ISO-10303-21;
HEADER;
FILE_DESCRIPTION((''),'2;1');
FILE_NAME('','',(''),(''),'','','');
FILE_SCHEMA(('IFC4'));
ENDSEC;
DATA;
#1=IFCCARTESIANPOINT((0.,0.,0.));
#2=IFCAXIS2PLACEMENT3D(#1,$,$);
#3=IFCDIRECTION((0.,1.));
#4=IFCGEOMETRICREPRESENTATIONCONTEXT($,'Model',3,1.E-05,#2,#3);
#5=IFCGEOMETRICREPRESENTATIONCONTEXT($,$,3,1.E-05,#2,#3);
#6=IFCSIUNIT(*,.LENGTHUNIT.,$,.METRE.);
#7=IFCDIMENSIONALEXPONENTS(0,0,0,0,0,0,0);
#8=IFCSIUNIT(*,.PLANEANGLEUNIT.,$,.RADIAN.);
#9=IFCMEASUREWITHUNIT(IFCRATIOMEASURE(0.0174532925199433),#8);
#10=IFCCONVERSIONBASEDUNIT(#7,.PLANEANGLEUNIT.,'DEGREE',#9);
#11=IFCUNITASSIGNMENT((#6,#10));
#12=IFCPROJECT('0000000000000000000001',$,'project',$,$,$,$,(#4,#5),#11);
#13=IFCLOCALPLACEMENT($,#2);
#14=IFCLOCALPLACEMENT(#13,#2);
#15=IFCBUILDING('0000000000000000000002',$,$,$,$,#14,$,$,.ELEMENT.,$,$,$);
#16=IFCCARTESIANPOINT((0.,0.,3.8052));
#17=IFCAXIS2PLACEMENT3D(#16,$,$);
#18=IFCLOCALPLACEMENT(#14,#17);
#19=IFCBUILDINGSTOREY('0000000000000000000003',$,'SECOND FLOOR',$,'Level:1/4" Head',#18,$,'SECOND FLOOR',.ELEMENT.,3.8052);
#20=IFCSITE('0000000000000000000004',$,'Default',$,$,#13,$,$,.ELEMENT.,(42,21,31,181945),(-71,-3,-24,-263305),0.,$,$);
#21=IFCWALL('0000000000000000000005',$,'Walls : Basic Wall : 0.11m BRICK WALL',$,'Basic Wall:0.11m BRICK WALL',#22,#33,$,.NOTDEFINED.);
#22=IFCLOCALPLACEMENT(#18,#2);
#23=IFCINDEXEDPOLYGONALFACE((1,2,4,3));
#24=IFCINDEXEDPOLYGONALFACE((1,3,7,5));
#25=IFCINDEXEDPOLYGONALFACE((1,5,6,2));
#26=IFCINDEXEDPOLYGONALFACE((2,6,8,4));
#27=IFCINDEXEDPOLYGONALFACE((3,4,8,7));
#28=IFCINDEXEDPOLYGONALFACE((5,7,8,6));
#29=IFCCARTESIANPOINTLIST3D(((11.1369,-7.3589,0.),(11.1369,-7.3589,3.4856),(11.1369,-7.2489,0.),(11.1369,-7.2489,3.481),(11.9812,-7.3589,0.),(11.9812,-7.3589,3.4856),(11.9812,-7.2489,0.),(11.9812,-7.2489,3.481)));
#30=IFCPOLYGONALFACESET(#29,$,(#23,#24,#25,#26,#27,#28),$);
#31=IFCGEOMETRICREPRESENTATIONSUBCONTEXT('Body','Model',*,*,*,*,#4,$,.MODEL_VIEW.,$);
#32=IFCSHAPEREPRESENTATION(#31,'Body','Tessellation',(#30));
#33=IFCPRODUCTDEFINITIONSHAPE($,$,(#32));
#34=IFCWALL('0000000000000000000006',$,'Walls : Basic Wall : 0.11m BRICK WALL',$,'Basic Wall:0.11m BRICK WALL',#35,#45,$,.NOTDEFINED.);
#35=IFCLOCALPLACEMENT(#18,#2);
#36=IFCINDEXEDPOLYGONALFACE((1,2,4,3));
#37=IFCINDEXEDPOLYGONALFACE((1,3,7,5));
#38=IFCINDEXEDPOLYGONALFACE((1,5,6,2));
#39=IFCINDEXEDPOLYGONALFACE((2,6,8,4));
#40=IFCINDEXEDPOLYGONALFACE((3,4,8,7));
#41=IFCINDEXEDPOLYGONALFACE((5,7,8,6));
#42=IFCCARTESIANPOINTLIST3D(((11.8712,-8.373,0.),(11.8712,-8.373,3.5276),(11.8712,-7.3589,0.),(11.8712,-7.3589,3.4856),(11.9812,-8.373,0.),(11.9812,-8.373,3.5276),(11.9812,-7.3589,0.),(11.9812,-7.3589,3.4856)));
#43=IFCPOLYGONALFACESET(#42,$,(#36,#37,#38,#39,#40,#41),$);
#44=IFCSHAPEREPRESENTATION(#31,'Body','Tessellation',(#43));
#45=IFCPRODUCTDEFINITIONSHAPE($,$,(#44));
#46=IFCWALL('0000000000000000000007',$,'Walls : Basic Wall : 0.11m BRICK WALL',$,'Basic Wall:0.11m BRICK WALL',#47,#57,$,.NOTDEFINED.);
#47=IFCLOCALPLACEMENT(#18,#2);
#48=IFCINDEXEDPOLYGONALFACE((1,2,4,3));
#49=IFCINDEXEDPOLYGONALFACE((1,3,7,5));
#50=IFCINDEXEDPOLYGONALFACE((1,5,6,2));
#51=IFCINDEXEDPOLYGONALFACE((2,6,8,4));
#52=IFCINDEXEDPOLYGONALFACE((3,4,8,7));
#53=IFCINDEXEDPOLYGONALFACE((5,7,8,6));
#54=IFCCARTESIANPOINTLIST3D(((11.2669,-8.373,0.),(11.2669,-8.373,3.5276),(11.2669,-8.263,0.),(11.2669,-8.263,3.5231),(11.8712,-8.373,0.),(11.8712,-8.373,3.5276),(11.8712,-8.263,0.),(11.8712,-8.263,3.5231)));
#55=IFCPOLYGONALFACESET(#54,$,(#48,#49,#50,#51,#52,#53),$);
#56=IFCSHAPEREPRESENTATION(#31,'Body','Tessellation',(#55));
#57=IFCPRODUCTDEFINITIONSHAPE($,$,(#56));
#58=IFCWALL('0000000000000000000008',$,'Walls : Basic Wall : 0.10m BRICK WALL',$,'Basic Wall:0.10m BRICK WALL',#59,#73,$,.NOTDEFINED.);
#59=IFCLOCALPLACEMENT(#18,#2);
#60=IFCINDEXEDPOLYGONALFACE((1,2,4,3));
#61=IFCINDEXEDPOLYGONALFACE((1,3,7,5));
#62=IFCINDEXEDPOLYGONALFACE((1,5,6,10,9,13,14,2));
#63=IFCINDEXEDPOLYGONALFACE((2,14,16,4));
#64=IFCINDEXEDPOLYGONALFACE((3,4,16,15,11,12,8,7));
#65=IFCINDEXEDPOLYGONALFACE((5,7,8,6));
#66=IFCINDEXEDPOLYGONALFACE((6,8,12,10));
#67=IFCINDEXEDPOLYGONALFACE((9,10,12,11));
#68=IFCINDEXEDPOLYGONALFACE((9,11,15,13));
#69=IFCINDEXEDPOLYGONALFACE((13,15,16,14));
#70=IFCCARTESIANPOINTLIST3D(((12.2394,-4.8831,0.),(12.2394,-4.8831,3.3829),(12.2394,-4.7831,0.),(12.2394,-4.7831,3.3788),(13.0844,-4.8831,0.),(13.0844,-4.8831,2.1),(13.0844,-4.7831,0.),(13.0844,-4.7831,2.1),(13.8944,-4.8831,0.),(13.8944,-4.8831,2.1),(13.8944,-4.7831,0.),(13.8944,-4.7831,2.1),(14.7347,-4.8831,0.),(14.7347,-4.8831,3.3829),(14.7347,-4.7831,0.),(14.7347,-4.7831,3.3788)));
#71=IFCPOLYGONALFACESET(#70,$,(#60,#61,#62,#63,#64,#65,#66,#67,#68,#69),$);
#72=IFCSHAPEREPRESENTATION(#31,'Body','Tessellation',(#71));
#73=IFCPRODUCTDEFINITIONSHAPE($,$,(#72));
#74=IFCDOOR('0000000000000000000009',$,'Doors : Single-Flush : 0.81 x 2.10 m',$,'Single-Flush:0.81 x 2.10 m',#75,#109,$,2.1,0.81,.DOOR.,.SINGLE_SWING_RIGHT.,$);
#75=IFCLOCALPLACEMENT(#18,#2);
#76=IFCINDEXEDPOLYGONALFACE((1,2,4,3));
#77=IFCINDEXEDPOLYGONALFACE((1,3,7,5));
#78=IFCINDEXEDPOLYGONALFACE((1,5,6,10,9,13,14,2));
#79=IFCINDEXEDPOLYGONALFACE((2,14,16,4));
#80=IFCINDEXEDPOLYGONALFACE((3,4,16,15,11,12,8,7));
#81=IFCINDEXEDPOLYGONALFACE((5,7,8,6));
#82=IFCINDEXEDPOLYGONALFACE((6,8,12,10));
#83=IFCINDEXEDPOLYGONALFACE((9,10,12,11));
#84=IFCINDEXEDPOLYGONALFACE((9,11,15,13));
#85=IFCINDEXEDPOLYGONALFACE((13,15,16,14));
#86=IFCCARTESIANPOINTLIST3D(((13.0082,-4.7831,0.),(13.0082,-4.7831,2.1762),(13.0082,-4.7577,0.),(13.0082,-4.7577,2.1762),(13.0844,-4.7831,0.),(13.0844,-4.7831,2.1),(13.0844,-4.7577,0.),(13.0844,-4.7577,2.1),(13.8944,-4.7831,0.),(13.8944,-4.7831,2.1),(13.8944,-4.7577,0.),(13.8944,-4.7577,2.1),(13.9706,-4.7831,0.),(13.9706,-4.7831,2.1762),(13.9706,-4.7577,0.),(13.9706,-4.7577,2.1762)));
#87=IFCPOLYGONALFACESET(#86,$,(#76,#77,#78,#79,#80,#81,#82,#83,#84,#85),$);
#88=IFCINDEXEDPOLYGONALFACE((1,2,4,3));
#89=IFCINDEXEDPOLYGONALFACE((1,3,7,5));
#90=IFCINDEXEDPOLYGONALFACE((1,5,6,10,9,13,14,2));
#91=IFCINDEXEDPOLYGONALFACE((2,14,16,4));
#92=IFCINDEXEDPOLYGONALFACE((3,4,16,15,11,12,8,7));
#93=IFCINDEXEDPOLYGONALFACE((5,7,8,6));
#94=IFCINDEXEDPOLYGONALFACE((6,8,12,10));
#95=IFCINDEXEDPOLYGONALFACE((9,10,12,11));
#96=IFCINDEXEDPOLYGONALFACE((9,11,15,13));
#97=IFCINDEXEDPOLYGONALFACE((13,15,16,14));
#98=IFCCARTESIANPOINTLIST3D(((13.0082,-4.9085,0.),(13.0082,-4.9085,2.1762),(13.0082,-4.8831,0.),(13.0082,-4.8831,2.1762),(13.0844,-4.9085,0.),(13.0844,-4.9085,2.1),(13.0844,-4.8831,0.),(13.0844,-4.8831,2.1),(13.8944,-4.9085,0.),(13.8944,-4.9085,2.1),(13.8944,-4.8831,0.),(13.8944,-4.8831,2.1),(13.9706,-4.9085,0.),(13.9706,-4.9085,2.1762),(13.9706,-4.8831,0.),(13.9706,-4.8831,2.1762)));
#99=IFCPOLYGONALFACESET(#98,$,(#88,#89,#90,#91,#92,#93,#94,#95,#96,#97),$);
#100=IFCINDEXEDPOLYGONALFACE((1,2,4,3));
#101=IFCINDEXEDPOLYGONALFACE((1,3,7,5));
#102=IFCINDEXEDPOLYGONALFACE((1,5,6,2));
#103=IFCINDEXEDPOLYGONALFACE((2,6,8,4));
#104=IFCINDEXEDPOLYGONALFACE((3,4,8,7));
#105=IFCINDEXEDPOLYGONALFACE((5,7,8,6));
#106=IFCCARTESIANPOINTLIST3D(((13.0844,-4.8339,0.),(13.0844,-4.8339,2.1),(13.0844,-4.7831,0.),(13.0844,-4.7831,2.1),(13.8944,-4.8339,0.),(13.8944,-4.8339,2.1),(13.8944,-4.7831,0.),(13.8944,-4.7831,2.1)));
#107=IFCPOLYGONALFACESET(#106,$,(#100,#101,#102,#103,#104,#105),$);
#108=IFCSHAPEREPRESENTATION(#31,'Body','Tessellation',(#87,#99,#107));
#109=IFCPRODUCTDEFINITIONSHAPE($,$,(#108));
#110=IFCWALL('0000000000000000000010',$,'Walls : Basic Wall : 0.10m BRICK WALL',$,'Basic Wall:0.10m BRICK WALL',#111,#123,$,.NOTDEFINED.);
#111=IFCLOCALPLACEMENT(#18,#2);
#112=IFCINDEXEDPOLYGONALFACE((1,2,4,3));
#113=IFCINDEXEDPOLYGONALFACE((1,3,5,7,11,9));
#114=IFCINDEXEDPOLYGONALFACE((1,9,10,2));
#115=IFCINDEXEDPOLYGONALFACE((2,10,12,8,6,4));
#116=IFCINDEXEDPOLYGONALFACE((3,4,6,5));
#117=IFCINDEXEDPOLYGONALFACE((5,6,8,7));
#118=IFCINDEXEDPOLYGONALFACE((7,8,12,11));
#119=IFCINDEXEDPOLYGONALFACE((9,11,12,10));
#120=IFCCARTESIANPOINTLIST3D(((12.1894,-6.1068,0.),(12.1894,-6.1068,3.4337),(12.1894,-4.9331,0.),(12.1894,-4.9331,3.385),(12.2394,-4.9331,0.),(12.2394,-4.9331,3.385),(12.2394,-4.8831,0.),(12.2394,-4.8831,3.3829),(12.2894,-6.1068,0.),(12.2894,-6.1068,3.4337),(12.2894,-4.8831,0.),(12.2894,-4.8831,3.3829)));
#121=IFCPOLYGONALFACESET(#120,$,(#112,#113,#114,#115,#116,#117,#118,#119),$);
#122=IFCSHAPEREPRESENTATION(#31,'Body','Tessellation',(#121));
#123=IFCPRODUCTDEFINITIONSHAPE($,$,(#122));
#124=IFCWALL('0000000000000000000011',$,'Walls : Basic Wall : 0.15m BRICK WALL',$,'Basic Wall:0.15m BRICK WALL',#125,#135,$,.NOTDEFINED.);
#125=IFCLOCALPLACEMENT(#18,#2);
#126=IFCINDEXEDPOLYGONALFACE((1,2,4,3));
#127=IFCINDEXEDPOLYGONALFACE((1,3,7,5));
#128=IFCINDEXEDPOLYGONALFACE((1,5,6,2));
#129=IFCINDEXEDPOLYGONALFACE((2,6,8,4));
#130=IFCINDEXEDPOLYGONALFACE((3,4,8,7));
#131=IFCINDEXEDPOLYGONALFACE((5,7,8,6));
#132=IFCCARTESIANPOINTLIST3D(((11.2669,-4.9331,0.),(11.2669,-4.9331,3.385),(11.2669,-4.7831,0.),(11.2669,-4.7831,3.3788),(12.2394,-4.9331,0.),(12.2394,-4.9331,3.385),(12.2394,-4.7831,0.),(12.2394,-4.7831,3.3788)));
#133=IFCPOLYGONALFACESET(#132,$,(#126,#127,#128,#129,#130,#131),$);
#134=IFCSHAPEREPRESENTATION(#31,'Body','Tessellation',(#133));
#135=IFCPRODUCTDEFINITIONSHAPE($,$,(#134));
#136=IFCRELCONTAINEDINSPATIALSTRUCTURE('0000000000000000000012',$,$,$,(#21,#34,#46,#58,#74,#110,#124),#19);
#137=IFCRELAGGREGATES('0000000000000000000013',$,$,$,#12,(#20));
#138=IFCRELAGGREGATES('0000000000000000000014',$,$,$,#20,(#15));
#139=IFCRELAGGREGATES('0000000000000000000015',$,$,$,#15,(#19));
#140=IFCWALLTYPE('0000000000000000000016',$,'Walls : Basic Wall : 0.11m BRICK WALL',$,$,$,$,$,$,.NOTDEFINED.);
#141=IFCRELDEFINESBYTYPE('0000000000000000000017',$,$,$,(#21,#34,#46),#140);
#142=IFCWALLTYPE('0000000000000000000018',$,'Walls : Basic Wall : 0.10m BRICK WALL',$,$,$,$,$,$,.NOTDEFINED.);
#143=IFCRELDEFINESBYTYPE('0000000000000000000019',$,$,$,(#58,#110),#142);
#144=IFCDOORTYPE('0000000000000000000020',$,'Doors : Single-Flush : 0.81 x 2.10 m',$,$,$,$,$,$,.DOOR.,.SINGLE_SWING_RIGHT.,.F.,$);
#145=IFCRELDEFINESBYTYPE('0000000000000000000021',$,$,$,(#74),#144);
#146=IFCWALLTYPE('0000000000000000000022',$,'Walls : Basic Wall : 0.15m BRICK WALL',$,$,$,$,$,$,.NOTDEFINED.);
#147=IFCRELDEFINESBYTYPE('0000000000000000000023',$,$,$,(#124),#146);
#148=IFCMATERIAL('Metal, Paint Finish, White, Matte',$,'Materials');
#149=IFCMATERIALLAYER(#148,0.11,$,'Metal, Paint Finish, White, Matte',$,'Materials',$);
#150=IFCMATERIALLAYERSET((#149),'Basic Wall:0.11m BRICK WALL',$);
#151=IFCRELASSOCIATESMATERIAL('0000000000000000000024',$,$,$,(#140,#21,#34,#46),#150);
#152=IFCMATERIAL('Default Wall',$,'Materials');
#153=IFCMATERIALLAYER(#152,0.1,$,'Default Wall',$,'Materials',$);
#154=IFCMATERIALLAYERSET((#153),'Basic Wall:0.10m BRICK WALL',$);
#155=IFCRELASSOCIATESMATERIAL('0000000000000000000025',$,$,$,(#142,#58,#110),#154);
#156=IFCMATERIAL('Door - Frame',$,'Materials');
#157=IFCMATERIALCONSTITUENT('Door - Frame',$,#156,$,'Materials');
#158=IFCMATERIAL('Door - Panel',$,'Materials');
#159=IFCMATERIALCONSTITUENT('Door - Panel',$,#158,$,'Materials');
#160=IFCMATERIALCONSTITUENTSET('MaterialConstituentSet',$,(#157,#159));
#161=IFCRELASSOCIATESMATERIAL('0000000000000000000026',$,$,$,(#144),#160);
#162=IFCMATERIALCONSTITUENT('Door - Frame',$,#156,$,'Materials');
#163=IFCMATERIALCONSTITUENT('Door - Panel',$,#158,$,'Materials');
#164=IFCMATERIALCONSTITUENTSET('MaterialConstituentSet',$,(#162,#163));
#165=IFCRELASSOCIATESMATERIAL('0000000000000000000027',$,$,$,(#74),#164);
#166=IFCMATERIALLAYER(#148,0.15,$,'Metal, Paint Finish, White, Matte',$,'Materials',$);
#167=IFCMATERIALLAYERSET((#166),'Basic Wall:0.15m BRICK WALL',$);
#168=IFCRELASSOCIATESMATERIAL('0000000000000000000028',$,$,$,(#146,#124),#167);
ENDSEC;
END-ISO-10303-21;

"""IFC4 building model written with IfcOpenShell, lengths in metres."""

from ifc_helpers import new_model, entity, si_unit, converted_unit, direction, frame, frame_2d, origin, origin_2d_with_axis, place, context, subcontext, project, spatial, polyline, rectangle, outline, extrude, clip, bounded_halfspace, source, transform, mapped, material, layer, layer_set, layer_usage, constituent, constituent_set, type_object, type_shapes, element, fill, save


model = new_model("IFC4")

# Units and contexts
model_context = context("Model", 3, precision=1e-05, world=origin(), true_north=direction((0.0, 1.0)))
context_of_model = context(None, 3, precision=1e-05, world=origin(), true_north=direction((0.0, 1.0)))
body_context = subcontext(model_context, "Body", "Model", "MODEL_VIEW")
ifc_project = project(units=[si_unit("LENGTHUNIT", "METRE"), converted_unit("PLANEANGLEUNIT", "DEGREE", entity("IfcRatioMeasure", 0.0174532925199433), si_unit("PLANEANGLEUNIT", "RADIAN"), dimensions=[0, 0, 0, 0, 0, 0, 0])], contexts=[model_context, context_of_model])

# Site, building, storey
site_placement = place(None, origin())
site = spatial("IfcSite", under=ifc_project, at=site_placement, Name="Default", CompositionType="ELEMENT", RefLatitude=(42, 21, 31, 181945), RefLongitude=(-71, -3, -24, -263305), RefElevation=0.0)
building_placement = place(site_placement, origin())
building = spatial("IfcBuilding", under=site, at=building_placement, CompositionType="ELEMENT")
storey_placement = place(building_placement, frame((0.0, 0.0, 3.8052)))
storey = spatial("IfcBuildingStorey", under=building, at=storey_placement, Name="SECOND FLOOR", ObjectType="Level:1/4\" Head", LongName="SECOND FLOOR", CompositionType="ELEMENT", Elevation=3.8052)

# Shared definitions
ifc_material_1 = material(Name="Metal, Paint Finish, White, Matte", Category="Materials")

# Shared definitions
ifc_material_2 = material(Name="Door - Frame", Category="Materials")
ifc_material_3 = material(Name="Door - Panel", Category="Materials")

# Walls
ifc_layer_1 = layer(ifc_material_1, 0.11, Name="Metal, Paint Finish, White, Matte", Category="Materials")
ifc_layer_set_1 = layer_set([ifc_layer_1], Name="Basic Wall:0.11m BRICK WALL")
ifc_layer_usage_1 = layer_usage(ifc_layer_set_1, "AXIS2", "NEGATIVE", 0.055)
wall_type_1 = type_object("IfcWallType", Name="Walls : Basic Wall : 0.11m BRICK WALL", PredefinedType="NOTDEFINED", material=ifc_layer_set_1)
wall_1_placement = place(storey_placement, frame((11.9812, -7.3039, 0.0), z_axis=(0.0, 0.0, 1.0), x_axis=(-1.0, 0.0, 0.0)))
element("IfcWall", 1, at=wall_1_placement, inside=storey, type_object=wall_type_1, material=ifc_layer_usage_1, Name="Walls : Basic Wall : 0.11m BRICK WALL", ObjectType="Basic Wall:0.11m BRICK WALL", PredefinedType="NOTDEFINED", context=body_context, shape_type="Clipping", body=[
    clip(extrude(rectangle(XDim=0.8442, YDim=0.11, at=frame_2d((0.4221, 0.0), x_axis=(-1.0, 0.0))), origin(), (0.0, 0.0, 1.0), 3.4856), bounded_halfspace(frame((0.0, -0.055, 3.481), z_axis=(0.0, 0.041435, -0.999141), x_axis=(1.0, 0.0, 0.0)), True, frame((0.0, -0.055, 3.481)), polyline([(0.0, 0.0), (0.8442, 0.0), (0.8442, 0.11), (0.11, 0.11), (0.0, 0.11), (0.0, 0.0)]))),
])
ifc_layer_usage_2 = layer_usage(ifc_layer_set_1, "AXIS2", "NEGATIVE", 0.055)
wall_2_placement = place(storey_placement, frame((11.9262, -8.373, 0.0), z_axis=(0.0, 0.0, 1.0), x_axis=(0.0, 1.0, 0.0)))
element("IfcWall", 2, at=wall_2_placement, inside=storey, type_object=wall_type_1, material=ifc_layer_usage_2, Name="Walls : Basic Wall : 0.11m BRICK WALL", ObjectType="Basic Wall:0.11m BRICK WALL", PredefinedType="NOTDEFINED", context=body_context, shape_type="Clipping", body=[
    clip(extrude(rectangle(XDim=1.0141, YDim=0.11, at=frame_2d((0.5071, 0.0), x_axis=(-1.0, 0.0))), origin(), (0.0, 0.0, 1.0), 3.5276), bounded_halfspace(frame((0.0, -0.055, 3.5276), z_axis=(-0.041435, 0.0, -0.999141), x_axis=(0.0, 1.0, 0.0)), True, frame((0.0, -0.055, 3.5276)), polyline([(0.0, 0.0), (1.0141, 0.0), (1.0141, 0.11), (0.11, 0.11), (0.0, 0.11), (0.0, 0.0)]))),
])
ifc_layer_usage_3 = layer_usage(ifc_layer_set_1, "AXIS2", "NEGATIVE", 0.055)
wall_3_placement = place(storey_placement, frame((11.2669, -8.318, 0.0)))
element("IfcWall", 3, at=wall_3_placement, inside=storey, type_object=wall_type_1, material=ifc_layer_usage_3, Name="Walls : Basic Wall : 0.11m BRICK WALL", ObjectType="Basic Wall:0.11m BRICK WALL", PredefinedType="NOTDEFINED", context=body_context, shape_type="Clipping", body=[
    clip(extrude(rectangle(XDim=0.6042, YDim=0.11, at=frame_2d((0.3021, 0.0), x_axis=(-1.0, 0.0))), origin(), (0.0, 0.0, 1.0), 3.5276), bounded_halfspace(frame((0.0, -0.055, 3.5276), z_axis=(0.0, -0.041435, -0.999141), x_axis=(-1.0, 0.0, 0.0)), True, frame((0.0, -0.055, 3.5276)), polyline([(0.0, 0.0), (0.6042, 0.0), (0.6042, 0.11), (0.0, 0.11), (0.0, 0.0)]))),
])

# Wall, opening, door
ifc_material_4 = material(Name="Default Wall", Category="Materials")
ifc_layer_2 = layer(ifc_material_4, 0.1, Name="Default Wall", Category="Materials")
ifc_layer_set_2 = layer_set([ifc_layer_2], Name="Basic Wall:0.10m BRICK WALL")
ifc_layer_usage_4 = layer_usage(ifc_layer_set_2, "AXIS2", "NEGATIVE", 0.05)
wall_type_2 = type_object("IfcWallType", Name="Walls : Basic Wall : 0.10m BRICK WALL", PredefinedType="NOTDEFINED", material=ifc_layer_set_2)
wall_4_placement = place(storey_placement, frame((14.7347, -4.8331, 0.0), z_axis=(0.0, 0.0, 1.0), x_axis=(-1.0, 0.0, 0.0)))
wall_4 = element("IfcWall", 4, at=wall_4_placement, inside=storey, type_object=wall_type_2, material=ifc_layer_usage_4, Name="Walls : Basic Wall : 0.10m BRICK WALL", ObjectType="Basic Wall:0.10m BRICK WALL", PredefinedType="NOTDEFINED", context=body_context, shape_type="Clipping", body=[
    clip(extrude(rectangle(XDim=2.4953, YDim=0.1, at=frame_2d((1.2476, 0.0), x_axis=(-1.0, 0.0))), origin(), (0.0, 0.0, 1.0), 3.3829), bounded_halfspace(frame((0.0, -0.05, 3.3788), z_axis=(0.0, 0.041435, -0.999141), x_axis=(1.0, 0.0, 0.0)), True, frame((0.0, -0.05, 3.3788)), polyline([(0.0, 0.0), (2.4953, 0.0), (2.4953, 0.1), (2.4453, 0.1), (0.0, 0.1), (0.0, 0.0)]))),
])
opening_1_placement = place(wall_4_placement, frame((1.6503, 0.05, 0.0)))
opening_1 = element("IfcOpeningElement", 5, at=opening_1_placement, cuts=wall_4, ObjectType="Opening", PredefinedType="OPENING", context=body_context, shape_type="SweptSolid", body=[
    extrude(rectangle(XDim=0.81, YDim=2.1, at=frame_2d((1.05, 0.405), x_axis=(0.0, 1.0))), frame((0.0, 0.0, 0.0), z_axis=(0.0, -1.0, 0.0), x_axis=(0.0, 0.0, 1.0)), (0.0, 0.0, 1.0), 0.1),
])
ifc_constituent_1 = constituent(ifc_material_2, Name="Door - Frame", Category="Materials")
ifc_constituent_2 = constituent(ifc_material_3, Name="Door - Panel", Category="Materials")
ifc_constituent_set_1 = constituent_set(constituents=[ifc_constituent_1, ifc_constituent_2], Name="MaterialConstituentSet")
ifc_constituent_3 = constituent(ifc_material_2, Name="Door - Frame", Category="Materials")
ifc_constituent_4 = constituent(ifc_material_3, Name="Door - Panel", Category="Materials")
ifc_constituent_set_2 = constituent_set(constituents=[ifc_constituent_3, ifc_constituent_4], Name="MaterialConstituentSet")
door_type_1 = type_object("IfcDoorType", Name="Doors : Single-Flush : 0.81 x 2.10 m", OperationType="SINGLE_SWING_RIGHT", ParameterTakesPrecedence=False, PredefinedType="DOOR", material=ifc_constituent_set_2)
shared_shape_1 = source(origin(), body_context, "Body", "SweptSolid", [
    extrude(outline(polyline([(-0.4812, -1.1072), (0.4812, -1.1072), (0.4812, 1.0691), (0.405, 1.0691), (0.405, -1.031), (-0.405, -1.031), (-0.405, 1.0691), (-0.4812, 1.0691), (-0.4812, -1.1072)])), frame((0.405, 0.1, 1.0691), z_axis=(0.0, 1.0, 0.0), x_axis=(1.0, 0.0, 0.0)), (0.0, 0.0, 1.0), 0.0254),
    extrude(outline(polyline([(-1.1072, -0.4812), (1.0691, -0.4812), (1.0691, -0.405), (-1.031, -0.405), (-1.031, 0.405), (1.0691, 0.405), (1.0691, 0.4812), (-1.1072, 0.4812), (-1.1072, -0.4812)])), frame((0.405, -0.0254, 1.0691), z_axis=(0.0, 1.0, 0.0), x_axis=(0.0, 0.0, -1.0)), (0.0, 0.0, 1.0), 0.0254),
    extrude(rectangle(XDim=0.0508, YDim=0.81, at=origin_2d_with_axis()), frame((0.405, 0.0746, 0.0), z_axis=(0.0, 0.0, 1.0), x_axis=(0.0, 1.0, 0.0)), (0.0, 0.0, 1.0), 2.1),
])
type_shapes(door_type_1, [shared_shape_1])
door_1_placement = place(opening_1_placement, frame((0.0, 0.0, 0.0), z_axis=(0.0, 0.0, 1.0), x_axis=(-1.0, 0.0, 0.0)))
door_1 = element("IfcDoor", 6, at=door_1_placement, inside=storey, type_object=door_type_1, material=ifc_constituent_set_1, Name="Doors : Single-Flush : 0.81 x 2.10 m", ObjectType="Single-Flush:0.81 x 2.10 m", OperationType="SINGLE_SWING_RIGHT", OverallHeight=2.1, OverallWidth=0.81, PredefinedType="DOOR", context=body_context, shape_type="MappedRepresentation", body=[
    mapped(shared_shape_1, transform((0.0, 0.0, 0.0), scale=1.0)),
])
fill(opening_1, door_1)

# Walls
ifc_layer_usage_5 = layer_usage(ifc_layer_set_2, "AXIS2", "NEGATIVE", 0.05)
wall_5_placement = place(storey_placement, frame((12.2394, -4.8831, 0.0), z_axis=(0.0, 0.0, 1.0), x_axis=(0.0, -1.0, 0.0)))
element("IfcWall", 7, at=wall_5_placement, inside=storey, type_object=wall_type_2, material=ifc_layer_usage_5, Name="Walls : Basic Wall : 0.10m BRICK WALL", ObjectType="Basic Wall:0.10m BRICK WALL", PredefinedType="NOTDEFINED", context=body_context, shape_type="Clipping", body=[
    clip(extrude(outline(polyline([(1.2238, -0.05), (1.2238, 0.05), (0.0, 0.05), (0.0, 0.0), (0.05, 0.0), (0.05, -0.05), (1.2238, -0.05)])), origin(), (0.0, 0.0, 1.0), 3.4337), bounded_halfspace(frame((0.05, -0.05, 3.385), z_axis=(0.041435, 0.0, -0.999141), x_axis=(0.0, -1.0, 0.0)), True, frame((0.05, -0.05, 3.385)), polyline([(0.0, 0.0), (1.1738, 0.0), (1.1738, 0.1), (-0.05, 0.1), (-0.05, 0.05), (0.0, 0.05), (0.0, 0.0)]))),
])
ifc_layer_3 = layer(ifc_material_1, 0.15, Name="Metal, Paint Finish, White, Matte", Category="Materials")
ifc_layer_set_3 = layer_set([ifc_layer_3], Name="Basic Wall:0.15m BRICK WALL")
ifc_layer_usage_6 = layer_usage(ifc_layer_set_3, "AXIS2", "NEGATIVE", 0.075)
wall_type_3 = type_object("IfcWallType", Name="Walls : Basic Wall : 0.15m BRICK WALL", PredefinedType="NOTDEFINED", material=ifc_layer_set_3)
wall_6_placement = place(storey_placement, frame((12.2394, -4.8581, 0.0), z_axis=(0.0, 0.0, 1.0), x_axis=(-1.0, 0.0, 0.0)))
element("IfcWall", 8, at=wall_6_placement, inside=storey, type_object=wall_type_3, material=ifc_layer_usage_6, Name="Walls : Basic Wall : 0.15m BRICK WALL", ObjectType="Basic Wall:0.15m BRICK WALL", PredefinedType="NOTDEFINED", context=body_context, shape_type="Clipping", body=[
    clip(extrude(rectangle(XDim=0.9725, YDim=0.15, at=frame_2d((0.4862, 0.0), x_axis=(-1.0, 0.0))), origin(), (0.0, 0.0, 1.0), 3.385), bounded_halfspace(frame((0.0, -0.075, 3.3788), z_axis=(0.0, 0.041435, -0.999141), x_axis=(1.0, 0.0, 0.0)), True, frame((0.0, -0.075, 3.3788)), polyline([(0.0, 0.0), (0.9725, 0.0), (0.9725, 0.15), (0.05, 0.15), (0.0, 0.15), (0.0, 0.1), (0.0, 0.0)]))),
])

save(model, "model.ifc")
